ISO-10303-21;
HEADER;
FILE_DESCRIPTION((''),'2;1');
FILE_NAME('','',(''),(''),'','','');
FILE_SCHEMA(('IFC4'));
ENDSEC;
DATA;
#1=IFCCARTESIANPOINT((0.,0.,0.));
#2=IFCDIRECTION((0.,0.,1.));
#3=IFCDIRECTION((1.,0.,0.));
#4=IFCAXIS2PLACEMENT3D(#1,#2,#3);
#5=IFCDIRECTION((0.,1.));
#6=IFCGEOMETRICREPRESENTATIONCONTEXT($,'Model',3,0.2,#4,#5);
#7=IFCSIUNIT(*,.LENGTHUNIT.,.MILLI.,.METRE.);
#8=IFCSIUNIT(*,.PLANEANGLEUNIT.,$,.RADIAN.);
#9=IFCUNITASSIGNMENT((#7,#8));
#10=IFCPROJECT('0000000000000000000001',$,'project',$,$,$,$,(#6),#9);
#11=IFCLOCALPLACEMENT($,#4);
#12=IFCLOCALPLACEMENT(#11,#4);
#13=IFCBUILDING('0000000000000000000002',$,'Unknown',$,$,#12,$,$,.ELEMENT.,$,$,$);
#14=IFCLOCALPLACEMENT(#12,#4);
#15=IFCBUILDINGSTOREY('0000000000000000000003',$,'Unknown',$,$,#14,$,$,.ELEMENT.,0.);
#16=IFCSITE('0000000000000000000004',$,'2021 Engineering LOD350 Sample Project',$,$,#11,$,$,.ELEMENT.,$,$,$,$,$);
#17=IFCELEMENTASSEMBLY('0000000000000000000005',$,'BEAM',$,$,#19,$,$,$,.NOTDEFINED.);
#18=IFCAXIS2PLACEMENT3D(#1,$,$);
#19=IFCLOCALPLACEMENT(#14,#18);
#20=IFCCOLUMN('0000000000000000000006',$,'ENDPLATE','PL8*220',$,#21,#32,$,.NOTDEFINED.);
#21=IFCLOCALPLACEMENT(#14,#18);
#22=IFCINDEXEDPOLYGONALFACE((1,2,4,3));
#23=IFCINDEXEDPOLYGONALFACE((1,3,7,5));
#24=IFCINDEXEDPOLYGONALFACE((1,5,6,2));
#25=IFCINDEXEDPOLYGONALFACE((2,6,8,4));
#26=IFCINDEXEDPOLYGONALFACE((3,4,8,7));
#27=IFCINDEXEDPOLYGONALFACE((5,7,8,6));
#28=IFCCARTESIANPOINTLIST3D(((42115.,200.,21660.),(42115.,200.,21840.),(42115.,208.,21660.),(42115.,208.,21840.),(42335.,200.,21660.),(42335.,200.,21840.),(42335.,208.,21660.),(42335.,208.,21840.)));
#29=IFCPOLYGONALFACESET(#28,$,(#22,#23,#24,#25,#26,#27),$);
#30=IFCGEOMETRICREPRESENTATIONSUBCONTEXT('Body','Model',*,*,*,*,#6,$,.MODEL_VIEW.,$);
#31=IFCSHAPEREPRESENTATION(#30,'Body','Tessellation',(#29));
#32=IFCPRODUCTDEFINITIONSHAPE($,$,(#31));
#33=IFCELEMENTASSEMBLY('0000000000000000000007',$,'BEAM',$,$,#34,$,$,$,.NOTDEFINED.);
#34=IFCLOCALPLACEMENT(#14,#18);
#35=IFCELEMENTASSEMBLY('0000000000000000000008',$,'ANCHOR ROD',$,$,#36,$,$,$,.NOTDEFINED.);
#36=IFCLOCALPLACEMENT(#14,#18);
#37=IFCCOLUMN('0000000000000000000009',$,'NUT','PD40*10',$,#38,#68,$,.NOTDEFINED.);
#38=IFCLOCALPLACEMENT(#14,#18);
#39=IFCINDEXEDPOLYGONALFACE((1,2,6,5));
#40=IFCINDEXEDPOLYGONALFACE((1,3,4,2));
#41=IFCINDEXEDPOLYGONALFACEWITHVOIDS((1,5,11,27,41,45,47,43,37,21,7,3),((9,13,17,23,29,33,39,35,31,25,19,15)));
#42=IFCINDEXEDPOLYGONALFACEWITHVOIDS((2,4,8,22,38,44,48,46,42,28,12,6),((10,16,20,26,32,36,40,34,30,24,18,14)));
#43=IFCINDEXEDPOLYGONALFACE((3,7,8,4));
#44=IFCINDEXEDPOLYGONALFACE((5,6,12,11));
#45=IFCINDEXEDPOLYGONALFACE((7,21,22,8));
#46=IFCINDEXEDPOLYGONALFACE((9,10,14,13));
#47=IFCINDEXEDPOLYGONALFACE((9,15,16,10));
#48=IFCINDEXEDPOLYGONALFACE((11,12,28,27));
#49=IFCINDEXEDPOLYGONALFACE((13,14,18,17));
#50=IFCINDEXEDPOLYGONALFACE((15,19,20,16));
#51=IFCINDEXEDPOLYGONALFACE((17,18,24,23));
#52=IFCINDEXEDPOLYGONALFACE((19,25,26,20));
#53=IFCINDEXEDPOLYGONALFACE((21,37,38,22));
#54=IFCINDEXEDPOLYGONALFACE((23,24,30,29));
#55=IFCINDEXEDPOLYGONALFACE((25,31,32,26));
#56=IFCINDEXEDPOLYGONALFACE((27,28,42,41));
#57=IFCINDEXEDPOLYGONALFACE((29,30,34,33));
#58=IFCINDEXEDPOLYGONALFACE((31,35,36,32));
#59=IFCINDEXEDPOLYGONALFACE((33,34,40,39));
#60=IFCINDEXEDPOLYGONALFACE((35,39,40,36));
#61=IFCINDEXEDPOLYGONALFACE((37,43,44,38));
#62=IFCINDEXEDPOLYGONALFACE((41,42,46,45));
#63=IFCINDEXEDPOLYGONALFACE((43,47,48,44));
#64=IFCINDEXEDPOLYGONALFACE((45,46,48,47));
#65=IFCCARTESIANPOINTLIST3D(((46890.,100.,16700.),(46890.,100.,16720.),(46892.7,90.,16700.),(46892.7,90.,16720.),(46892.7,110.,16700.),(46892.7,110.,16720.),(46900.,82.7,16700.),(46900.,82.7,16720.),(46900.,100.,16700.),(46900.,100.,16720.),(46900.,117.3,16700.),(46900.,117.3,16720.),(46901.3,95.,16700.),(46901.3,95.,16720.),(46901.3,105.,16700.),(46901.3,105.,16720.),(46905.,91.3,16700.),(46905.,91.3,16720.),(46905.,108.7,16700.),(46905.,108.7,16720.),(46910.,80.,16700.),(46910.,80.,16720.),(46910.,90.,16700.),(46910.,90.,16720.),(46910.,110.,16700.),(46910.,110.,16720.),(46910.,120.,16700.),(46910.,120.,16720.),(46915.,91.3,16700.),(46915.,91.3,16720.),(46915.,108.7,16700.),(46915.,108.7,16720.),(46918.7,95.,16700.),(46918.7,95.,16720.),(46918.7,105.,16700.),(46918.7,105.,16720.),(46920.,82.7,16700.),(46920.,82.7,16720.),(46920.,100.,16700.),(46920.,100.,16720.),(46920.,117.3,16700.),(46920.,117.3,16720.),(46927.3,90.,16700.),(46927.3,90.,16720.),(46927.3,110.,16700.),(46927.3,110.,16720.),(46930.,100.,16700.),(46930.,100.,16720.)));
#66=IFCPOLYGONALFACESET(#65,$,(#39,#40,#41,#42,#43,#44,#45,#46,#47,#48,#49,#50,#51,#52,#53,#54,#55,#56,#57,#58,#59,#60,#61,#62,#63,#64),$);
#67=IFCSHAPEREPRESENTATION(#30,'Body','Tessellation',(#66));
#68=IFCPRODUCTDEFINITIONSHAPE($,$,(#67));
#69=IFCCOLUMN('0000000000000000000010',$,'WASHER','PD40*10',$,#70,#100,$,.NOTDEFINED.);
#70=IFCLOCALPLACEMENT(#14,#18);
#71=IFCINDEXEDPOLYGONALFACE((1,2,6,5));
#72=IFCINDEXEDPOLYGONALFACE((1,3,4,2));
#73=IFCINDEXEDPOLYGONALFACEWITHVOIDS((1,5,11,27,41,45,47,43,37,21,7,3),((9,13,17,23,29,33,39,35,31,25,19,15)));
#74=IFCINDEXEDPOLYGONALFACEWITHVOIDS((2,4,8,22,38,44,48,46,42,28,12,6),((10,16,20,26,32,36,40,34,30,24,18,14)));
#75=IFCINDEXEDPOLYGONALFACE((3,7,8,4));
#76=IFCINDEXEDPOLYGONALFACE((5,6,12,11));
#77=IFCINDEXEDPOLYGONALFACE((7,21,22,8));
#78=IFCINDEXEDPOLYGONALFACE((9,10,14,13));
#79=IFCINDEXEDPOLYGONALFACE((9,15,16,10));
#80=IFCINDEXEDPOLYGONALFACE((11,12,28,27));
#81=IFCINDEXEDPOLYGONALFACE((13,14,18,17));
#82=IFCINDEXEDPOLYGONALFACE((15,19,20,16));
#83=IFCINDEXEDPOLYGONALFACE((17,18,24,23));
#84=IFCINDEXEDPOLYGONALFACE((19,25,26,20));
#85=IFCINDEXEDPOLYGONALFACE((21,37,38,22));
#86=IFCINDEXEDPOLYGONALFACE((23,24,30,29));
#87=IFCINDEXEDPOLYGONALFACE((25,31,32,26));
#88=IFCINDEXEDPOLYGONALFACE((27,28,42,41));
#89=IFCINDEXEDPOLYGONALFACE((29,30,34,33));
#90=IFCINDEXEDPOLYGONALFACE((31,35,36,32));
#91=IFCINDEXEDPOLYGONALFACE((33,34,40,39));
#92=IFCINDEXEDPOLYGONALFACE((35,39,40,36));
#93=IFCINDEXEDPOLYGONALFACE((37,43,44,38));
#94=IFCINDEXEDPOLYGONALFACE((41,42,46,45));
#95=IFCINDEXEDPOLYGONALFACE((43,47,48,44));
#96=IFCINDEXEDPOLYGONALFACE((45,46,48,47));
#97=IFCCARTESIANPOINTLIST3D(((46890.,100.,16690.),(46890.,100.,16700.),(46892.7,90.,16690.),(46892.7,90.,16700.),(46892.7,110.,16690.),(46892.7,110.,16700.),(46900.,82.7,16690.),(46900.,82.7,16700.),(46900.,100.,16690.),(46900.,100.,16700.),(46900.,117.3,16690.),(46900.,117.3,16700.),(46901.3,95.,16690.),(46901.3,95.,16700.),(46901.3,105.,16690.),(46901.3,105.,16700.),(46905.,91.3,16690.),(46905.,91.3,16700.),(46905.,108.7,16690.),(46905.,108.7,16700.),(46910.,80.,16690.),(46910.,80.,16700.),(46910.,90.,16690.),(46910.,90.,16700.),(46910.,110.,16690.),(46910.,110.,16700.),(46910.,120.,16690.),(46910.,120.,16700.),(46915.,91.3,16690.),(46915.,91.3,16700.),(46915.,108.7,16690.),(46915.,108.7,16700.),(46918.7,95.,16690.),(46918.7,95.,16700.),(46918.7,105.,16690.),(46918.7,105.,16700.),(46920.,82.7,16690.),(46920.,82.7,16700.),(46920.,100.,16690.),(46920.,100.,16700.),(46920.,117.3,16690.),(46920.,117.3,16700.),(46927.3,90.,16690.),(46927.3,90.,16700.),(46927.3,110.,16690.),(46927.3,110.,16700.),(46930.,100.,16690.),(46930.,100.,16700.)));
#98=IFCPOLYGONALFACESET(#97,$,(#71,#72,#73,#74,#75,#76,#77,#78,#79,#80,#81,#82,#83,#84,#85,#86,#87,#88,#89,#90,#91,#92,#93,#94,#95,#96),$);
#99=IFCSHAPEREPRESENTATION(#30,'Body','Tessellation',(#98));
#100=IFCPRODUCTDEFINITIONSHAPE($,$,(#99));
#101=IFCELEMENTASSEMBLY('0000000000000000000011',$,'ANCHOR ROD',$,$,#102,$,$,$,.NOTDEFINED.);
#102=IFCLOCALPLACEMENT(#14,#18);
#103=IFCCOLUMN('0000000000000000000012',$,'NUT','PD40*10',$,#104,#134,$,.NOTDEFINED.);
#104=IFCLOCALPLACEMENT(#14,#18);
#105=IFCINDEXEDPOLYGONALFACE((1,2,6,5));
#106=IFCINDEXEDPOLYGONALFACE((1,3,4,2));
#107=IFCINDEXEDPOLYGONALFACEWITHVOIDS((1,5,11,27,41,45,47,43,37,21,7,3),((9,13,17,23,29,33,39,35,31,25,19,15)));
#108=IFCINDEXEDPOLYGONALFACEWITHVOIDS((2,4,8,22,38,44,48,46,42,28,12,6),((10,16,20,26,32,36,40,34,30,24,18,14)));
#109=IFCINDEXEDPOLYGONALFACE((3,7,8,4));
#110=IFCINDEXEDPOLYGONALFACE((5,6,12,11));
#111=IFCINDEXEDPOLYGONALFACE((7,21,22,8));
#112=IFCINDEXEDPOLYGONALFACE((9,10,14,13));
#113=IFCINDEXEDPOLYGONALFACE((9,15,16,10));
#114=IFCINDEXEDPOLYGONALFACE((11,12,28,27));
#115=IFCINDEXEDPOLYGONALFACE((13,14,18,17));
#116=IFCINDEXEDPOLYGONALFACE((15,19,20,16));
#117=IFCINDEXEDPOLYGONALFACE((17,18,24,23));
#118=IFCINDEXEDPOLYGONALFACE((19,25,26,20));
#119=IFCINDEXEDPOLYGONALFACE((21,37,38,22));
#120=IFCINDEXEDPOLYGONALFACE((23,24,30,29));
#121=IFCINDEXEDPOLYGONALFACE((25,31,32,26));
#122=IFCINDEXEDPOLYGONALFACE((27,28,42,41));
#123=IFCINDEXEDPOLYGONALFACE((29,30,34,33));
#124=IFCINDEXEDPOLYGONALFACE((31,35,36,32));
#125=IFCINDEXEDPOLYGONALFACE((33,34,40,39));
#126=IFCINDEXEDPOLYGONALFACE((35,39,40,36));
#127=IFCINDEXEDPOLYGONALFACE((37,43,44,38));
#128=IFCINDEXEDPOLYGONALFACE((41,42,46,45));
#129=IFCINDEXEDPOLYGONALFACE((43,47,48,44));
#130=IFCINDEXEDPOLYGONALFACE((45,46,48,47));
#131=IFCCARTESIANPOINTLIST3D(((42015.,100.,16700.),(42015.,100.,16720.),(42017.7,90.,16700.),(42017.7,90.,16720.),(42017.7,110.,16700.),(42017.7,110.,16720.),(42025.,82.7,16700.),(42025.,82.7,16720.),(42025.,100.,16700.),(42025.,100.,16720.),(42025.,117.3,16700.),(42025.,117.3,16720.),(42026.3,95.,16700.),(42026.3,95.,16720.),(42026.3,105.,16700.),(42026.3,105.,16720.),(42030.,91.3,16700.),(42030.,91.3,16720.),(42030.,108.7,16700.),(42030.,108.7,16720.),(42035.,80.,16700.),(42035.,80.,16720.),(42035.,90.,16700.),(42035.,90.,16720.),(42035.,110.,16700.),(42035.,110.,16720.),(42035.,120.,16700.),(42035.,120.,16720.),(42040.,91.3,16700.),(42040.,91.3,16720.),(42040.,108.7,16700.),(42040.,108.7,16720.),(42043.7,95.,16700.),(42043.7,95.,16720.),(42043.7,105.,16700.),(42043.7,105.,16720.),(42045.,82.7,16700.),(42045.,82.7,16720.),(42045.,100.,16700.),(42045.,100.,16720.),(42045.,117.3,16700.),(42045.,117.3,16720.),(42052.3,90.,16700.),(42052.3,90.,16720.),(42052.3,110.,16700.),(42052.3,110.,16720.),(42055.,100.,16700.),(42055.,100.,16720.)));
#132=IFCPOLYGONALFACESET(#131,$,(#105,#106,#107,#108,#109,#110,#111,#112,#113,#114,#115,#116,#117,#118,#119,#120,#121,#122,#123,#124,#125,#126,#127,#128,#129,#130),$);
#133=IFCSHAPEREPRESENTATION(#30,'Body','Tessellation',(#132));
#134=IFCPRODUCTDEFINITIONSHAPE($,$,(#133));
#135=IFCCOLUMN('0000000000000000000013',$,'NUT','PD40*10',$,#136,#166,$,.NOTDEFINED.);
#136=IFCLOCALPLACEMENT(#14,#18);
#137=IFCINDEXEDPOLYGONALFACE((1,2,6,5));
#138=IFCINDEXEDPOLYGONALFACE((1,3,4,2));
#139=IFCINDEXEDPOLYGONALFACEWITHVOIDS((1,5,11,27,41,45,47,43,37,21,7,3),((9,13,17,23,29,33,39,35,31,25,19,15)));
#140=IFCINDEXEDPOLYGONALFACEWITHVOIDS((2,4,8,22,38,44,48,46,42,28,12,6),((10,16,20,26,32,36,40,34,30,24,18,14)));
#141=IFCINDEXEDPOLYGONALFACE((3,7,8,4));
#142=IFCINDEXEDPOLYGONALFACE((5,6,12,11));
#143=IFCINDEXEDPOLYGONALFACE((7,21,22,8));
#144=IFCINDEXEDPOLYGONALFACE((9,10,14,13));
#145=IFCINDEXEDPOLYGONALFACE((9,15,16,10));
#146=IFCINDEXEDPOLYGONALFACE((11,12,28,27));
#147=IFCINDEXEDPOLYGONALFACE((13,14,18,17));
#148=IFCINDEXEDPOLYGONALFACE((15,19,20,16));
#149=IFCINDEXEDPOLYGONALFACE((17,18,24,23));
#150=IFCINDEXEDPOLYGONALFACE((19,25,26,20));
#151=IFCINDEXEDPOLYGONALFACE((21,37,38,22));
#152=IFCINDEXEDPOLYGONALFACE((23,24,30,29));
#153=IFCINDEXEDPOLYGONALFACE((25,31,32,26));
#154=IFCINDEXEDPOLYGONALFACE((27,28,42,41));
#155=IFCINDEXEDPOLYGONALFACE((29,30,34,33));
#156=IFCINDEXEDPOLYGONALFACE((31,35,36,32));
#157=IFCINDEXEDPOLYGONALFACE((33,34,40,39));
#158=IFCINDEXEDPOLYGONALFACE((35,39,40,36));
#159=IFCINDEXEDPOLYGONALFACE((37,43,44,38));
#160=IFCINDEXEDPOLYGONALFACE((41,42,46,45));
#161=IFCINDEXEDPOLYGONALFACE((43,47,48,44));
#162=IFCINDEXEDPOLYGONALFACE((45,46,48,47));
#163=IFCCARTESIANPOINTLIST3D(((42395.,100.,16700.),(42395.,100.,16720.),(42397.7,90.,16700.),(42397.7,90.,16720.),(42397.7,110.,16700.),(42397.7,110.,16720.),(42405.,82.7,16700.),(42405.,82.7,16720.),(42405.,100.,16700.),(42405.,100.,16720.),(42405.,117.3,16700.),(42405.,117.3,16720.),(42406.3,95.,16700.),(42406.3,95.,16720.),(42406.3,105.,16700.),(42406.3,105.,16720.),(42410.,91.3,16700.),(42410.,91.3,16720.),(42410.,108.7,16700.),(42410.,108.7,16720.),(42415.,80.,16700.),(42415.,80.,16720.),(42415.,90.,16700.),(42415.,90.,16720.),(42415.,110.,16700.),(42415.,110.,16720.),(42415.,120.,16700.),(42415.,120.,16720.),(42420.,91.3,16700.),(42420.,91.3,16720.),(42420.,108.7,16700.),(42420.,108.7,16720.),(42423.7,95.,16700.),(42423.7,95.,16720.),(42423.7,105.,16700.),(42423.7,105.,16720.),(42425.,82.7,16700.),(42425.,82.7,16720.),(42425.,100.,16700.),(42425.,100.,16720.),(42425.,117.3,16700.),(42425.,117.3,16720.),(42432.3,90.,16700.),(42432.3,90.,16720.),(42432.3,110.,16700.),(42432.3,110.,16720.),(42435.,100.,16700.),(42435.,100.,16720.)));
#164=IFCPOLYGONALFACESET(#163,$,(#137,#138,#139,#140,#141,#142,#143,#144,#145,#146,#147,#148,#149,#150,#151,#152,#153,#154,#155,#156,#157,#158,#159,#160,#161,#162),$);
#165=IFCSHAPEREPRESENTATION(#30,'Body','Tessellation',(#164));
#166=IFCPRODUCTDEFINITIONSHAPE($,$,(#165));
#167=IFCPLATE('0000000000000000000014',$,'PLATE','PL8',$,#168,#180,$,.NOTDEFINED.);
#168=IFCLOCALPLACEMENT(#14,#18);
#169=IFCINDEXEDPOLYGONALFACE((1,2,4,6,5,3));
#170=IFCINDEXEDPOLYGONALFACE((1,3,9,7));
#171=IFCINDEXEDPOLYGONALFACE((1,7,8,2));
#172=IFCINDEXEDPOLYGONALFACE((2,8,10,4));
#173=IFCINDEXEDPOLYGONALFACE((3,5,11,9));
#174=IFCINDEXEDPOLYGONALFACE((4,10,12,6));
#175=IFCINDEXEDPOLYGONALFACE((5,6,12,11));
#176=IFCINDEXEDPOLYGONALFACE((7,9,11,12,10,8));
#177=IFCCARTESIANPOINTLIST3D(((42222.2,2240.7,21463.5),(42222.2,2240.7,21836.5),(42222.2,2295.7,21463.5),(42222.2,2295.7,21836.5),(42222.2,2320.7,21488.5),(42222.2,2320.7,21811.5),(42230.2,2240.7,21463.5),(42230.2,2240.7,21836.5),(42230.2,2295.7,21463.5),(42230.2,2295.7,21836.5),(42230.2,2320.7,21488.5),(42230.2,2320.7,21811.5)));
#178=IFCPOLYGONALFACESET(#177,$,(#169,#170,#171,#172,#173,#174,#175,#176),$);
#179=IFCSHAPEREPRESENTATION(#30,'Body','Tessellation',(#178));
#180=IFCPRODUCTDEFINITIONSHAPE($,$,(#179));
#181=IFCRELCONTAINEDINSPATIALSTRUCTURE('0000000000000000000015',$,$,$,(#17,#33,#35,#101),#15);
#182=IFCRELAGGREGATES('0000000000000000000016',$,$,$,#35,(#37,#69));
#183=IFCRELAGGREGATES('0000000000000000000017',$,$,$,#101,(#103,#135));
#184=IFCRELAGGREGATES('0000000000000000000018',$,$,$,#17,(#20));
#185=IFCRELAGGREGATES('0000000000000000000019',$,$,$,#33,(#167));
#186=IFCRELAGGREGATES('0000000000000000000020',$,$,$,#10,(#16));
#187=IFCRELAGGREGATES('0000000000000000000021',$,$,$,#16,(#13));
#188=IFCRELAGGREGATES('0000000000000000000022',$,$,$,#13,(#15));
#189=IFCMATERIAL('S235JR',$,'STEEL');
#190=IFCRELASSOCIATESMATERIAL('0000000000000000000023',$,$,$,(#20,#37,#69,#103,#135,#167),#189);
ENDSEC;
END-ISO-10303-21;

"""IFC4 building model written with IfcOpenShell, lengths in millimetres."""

from ifc_helpers import new_model, si_unit, direction, frame, origin_with_axes, place, context, subcontext, project, spatial, line, indexed_curve, outline, extrude, material, element, aggregate, save


model = new_model("IFC4")

# Units and contexts
model_context = context("Model", 3, precision=0.2, world=origin_with_axes(), true_north=direction((0.0, 1.0)))
body_context = subcontext(model_context, "Body", "Model", "MODEL_VIEW")
ifc_project = project(units=[si_unit("LENGTHUNIT", "METRE", prefix="MILLI"), si_unit("PLANEANGLEUNIT", "RADIAN")], contexts=[model_context])

# Site, building, storey
site_placement = place(None, origin_with_axes())
site = spatial("IfcSite", under=ifc_project, at=site_placement, Name="2021 Engineering LOD350 Sample Project", CompositionType="ELEMENT")
building_placement = place(site_placement, origin_with_axes())
building = spatial("IfcBuilding", under=site, at=building_placement, Name="Unknown", CompositionType="ELEMENT")
storey_placement = place(building_placement, origin_with_axes())
storey = spatial("IfcBuildingStorey", under=building, at=storey_placement, Name="Unknown", CompositionType="ELEMENT", Elevation=0.0)

# Element assembly, column
assembly_1_placement = place(storey_placement, frame((42225.0, 0.0, 21750.0), z_axis=(1.0, 0.0, 0.0), x_axis=(0.0, 1.0, 0.0)))
assembly_1 = element("IfcElementAssembly", 1, at=assembly_1_placement, inside=storey, Name="BEAM", PredefinedType="NOTDEFINED")
ifc_material_1 = material(Name="S235JR", Category="STEEL")
column_1_placement = place(assembly_1_placement, frame((204.0, -90.0, 0.0), z_axis=(1.0, 0.0, 0.0), x_axis=(0.0, 1.0, 0.0)))
column_1 = element("IfcColumn", 2, at=column_1_placement, material=ifc_material_1, Name="ENDPLATE", Description="PL8*220", PredefinedType="NOTDEFINED", context=body_context, shape_type="SolidModel", body=[
    extrude(outline(indexed_curve([(-4.0, -110.0), (4.0, -110.0), (4.0, 110.0), (-4.0, 110.0)], segments=[line(1, 2, 3, 4, 1)])), frame((0.0, 0.0, 0.0), z_axis=(-1.0, 0.0, 0.0), x_axis=(0.0, 0.0, 1.0)), (0.0, 0.0, -1.0), 180.0),
])

# Element assembly
assembly_2_placement = place(storey_placement, frame((37350.0, 2325.0, 21650.0), z_axis=(0.0, -1.0, 0.0), x_axis=(1.0, 0.0, 0.0)))
assembly_2 = element("IfcElementAssembly", 3, at=assembly_2_placement, inside=storey, Name="BEAM", PredefinedType="NOTDEFINED")

# Element assemblies, columns
assembly_3_placement = place(storey_placement, frame((47290.0, 100.0, 16730.0), z_axis=(1.0, 0.0, 0.0), x_axis=(0.0, 0.0, -1.0)))
assembly_3 = element("IfcElementAssembly", 4, at=assembly_3_placement, inside=storey, Name="ANCHOR ROD", PredefinedType="NOTDEFINED")
column_2_placement = place(assembly_3_placement, frame((10.0, 0.0, -380.0), z_axis=(0.0, 0.0, -1.0), x_axis=(1.0, 0.0, 0.0)))
column_2 = element("IfcColumn", 5, at=column_2_placement, material=ifc_material_1, Name="NUT", Description="PD40*10", PredefinedType="NOTDEFINED", context=body_context, shape_type="SolidModel", body=[
    extrude(outline(indexed_curve([(20.0, 0.0), (17.3, 10.0), (10.0, 17.3), (0.0, 20.0), (-10.0, 17.3), (-17.3, 10.0), (-20.0, 0.0), (-17.3, -10.0), (-10.0, -17.3), (0.0, -20.0), (10.0, -17.3), (17.3, -10.0)], segments=[line(1, 2, 3, 4, 5, 6, 7, 8, 9, 10, 11, 12, 1)]), holes=[indexed_curve([(10.0, 0.0), (8.7, -5.0), (5.0, -8.7), (0.0, -10.0), (-5.0, -8.7), (-8.7, -5.0), (-10.0, 0.0), (-8.7, 5.0), (-5.0, 8.7), (0.0, 10.0), (5.0, 8.7), (8.7, 5.0)], segments=[line(1, 2, 3, 4, 5, 6, 7, 8, 9, 10, 11, 12, 1)])]), frame((0.0, 0.0, 0.0), z_axis=(-1.0, 0.0, 0.0), x_axis=(0.0, 0.0, 1.0)), (0.0, 0.0, -1.0), 20.0),
])
column_3_placement = place(assembly_3_placement, frame((30.0, 0.0, -380.0), z_axis=(0.0, 0.0, -1.0), x_axis=(1.0, 0.0, 0.0)))
column_3 = element("IfcColumn", 6, at=column_3_placement, material=ifc_material_1, Name="WASHER", Description="PD40*10", PredefinedType="NOTDEFINED", context=body_context, shape_type="SolidModel", body=[
    extrude(outline(indexed_curve([(20.0, 0.0), (17.3, 10.0), (10.0, 17.3), (0.0, 20.0), (-10.0, 17.3), (-17.3, 10.0), (-20.0, 0.0), (-17.3, -10.0), (-10.0, -17.3), (0.0, -20.0), (10.0, -17.3), (17.3, -10.0)], segments=[line(1, 2, 3, 4, 5, 6, 7, 8, 9, 10, 11, 12, 1)]), holes=[indexed_curve([(10.0, 0.0), (8.7, -5.0), (5.0, -8.7), (0.0, -10.0), (-5.0, -8.7), (-8.7, -5.0), (-10.0, 0.0), (-8.7, 5.0), (-5.0, 8.7), (0.0, 10.0), (5.0, 8.7), (8.7, 5.0)], segments=[line(1, 2, 3, 4, 5, 6, 7, 8, 9, 10, 11, 12, 1)])]), frame((0.0, 0.0, 0.0), z_axis=(-1.0, 0.0, 0.0), x_axis=(0.0, 0.0, 1.0)), (0.0, 0.0, -1.0), 10.0),
])
assembly_4_placement = place(storey_placement, frame((42415.0, 100.0, 16730.0), z_axis=(1.0, 0.0, 0.0), x_axis=(0.0, 0.0, -1.0)))
assembly_4 = element("IfcElementAssembly", 7, at=assembly_4_placement, inside=storey, Name="ANCHOR ROD", PredefinedType="NOTDEFINED")
column_4_placement = place(assembly_4_placement, frame((10.0, 0.0, -380.0), z_axis=(0.0, 0.0, -1.0), x_axis=(1.0, 0.0, 0.0)))
column_4 = element("IfcColumn", 8, at=column_4_placement, material=ifc_material_1, Name="NUT", Description="PD40*10", PredefinedType="NOTDEFINED", context=body_context, shape_type="SolidModel", body=[
    extrude(outline(indexed_curve([(20.0, 0.0), (17.3, 10.0), (10.0, 17.3), (0.0, 20.0), (-10.0, 17.3), (-17.3, 10.0), (-20.0, 0.0), (-17.3, -10.0), (-10.0, -17.3), (0.0, -20.0), (10.0, -17.3), (17.3, -10.0)], segments=[line(1, 2, 3, 4, 5, 6, 7, 8, 9, 10, 11, 12, 1)]), holes=[indexed_curve([(10.0, 0.0), (8.7, -5.0), (5.0, -8.7), (0.0, -10.0), (-5.0, -8.7), (-8.7, -5.0), (-10.0, 0.0), (-8.7, 5.0), (-5.0, 8.7), (0.0, 10.0), (5.0, 8.7), (8.7, 5.0)], segments=[line(1, 2, 3, 4, 5, 6, 7, 8, 9, 10, 11, 12, 1)])]), frame((0.0, 0.0, 0.0), z_axis=(-1.0, 0.0, 0.0), x_axis=(0.0, 0.0, 1.0)), (0.0, 0.0, -1.0), 20.0),
])
column_5_placement = place(assembly_4_placement, frame((10.0, 0.0, 0.0), z_axis=(0.0, 0.0, 1.0), x_axis=(1.0, 0.0, 0.0)))
column_5 = element("IfcColumn", 9, at=column_5_placement, material=ifc_material_1, Name="NUT", Description="PD40*10", PredefinedType="NOTDEFINED", context=body_context, shape_type="SolidModel", body=[
    extrude(outline(indexed_curve([(20.0, 0.0), (17.3, 10.0), (10.0, 17.3), (0.0, 20.0), (-10.0, 17.3), (-17.3, 10.0), (-20.0, 0.0), (-17.3, -10.0), (-10.0, -17.3), (0.0, -20.0), (10.0, -17.3), (17.3, -10.0)], segments=[line(1, 2, 3, 4, 5, 6, 7, 8, 9, 10, 11, 12, 1)]), holes=[indexed_curve([(10.0, 0.0), (8.7, -5.0), (5.0, -8.7), (0.0, -10.0), (-5.0, -8.7), (-8.7, -5.0), (-10.0, 0.0), (-8.7, 5.0), (-5.0, 8.7), (0.0, 10.0), (5.0, 8.7), (8.7, 5.0)], segments=[line(1, 2, 3, 4, 5, 6, 7, 8, 9, 10, 11, 12, 1)])]), frame((0.0, 0.0, 0.0), z_axis=(-1.0, 0.0, 0.0), x_axis=(0.0, 0.0, 1.0)), (0.0, 0.0, -1.0), 20.0),
])

# Plate
plate_1_placement = place(assembly_2_placement, frame((4876.2, -186.5, 4.3), z_axis=(-1.0, 0.0, 0.0), x_axis=(0.0, 0.0, 1.0)))
plate_1 = element("IfcPlate", 10, at=plate_1_placement, material=ifc_material_1, Name="PLATE", Description="PL8", PredefinedType="NOTDEFINED", context=body_context, shape_type="SolidModel", body=[
    extrude(outline(indexed_curve([(0.0, 25.0), (25.0, 0.0), (80.0, 0.0), (80.0, 373.0), (25.0, 373.0), (0.0, 348.0)], segments=[line(1, 2, 3, 4, 5, 6, 1)])), frame((0.0, 0.0, 4.0), z_axis=(0.0, 0.0, 1.0), x_axis=(1.0, 0.0, 0.0)), (0.0, 0.0, -1.0), 8.0),
])

aggregate(assembly_3, [column_2, column_3])
aggregate(assembly_4, [column_4, column_5])

aggregate(assembly_1, [column_1])
aggregate(assembly_2, [plate_1])

save(model, "model.ifc")
